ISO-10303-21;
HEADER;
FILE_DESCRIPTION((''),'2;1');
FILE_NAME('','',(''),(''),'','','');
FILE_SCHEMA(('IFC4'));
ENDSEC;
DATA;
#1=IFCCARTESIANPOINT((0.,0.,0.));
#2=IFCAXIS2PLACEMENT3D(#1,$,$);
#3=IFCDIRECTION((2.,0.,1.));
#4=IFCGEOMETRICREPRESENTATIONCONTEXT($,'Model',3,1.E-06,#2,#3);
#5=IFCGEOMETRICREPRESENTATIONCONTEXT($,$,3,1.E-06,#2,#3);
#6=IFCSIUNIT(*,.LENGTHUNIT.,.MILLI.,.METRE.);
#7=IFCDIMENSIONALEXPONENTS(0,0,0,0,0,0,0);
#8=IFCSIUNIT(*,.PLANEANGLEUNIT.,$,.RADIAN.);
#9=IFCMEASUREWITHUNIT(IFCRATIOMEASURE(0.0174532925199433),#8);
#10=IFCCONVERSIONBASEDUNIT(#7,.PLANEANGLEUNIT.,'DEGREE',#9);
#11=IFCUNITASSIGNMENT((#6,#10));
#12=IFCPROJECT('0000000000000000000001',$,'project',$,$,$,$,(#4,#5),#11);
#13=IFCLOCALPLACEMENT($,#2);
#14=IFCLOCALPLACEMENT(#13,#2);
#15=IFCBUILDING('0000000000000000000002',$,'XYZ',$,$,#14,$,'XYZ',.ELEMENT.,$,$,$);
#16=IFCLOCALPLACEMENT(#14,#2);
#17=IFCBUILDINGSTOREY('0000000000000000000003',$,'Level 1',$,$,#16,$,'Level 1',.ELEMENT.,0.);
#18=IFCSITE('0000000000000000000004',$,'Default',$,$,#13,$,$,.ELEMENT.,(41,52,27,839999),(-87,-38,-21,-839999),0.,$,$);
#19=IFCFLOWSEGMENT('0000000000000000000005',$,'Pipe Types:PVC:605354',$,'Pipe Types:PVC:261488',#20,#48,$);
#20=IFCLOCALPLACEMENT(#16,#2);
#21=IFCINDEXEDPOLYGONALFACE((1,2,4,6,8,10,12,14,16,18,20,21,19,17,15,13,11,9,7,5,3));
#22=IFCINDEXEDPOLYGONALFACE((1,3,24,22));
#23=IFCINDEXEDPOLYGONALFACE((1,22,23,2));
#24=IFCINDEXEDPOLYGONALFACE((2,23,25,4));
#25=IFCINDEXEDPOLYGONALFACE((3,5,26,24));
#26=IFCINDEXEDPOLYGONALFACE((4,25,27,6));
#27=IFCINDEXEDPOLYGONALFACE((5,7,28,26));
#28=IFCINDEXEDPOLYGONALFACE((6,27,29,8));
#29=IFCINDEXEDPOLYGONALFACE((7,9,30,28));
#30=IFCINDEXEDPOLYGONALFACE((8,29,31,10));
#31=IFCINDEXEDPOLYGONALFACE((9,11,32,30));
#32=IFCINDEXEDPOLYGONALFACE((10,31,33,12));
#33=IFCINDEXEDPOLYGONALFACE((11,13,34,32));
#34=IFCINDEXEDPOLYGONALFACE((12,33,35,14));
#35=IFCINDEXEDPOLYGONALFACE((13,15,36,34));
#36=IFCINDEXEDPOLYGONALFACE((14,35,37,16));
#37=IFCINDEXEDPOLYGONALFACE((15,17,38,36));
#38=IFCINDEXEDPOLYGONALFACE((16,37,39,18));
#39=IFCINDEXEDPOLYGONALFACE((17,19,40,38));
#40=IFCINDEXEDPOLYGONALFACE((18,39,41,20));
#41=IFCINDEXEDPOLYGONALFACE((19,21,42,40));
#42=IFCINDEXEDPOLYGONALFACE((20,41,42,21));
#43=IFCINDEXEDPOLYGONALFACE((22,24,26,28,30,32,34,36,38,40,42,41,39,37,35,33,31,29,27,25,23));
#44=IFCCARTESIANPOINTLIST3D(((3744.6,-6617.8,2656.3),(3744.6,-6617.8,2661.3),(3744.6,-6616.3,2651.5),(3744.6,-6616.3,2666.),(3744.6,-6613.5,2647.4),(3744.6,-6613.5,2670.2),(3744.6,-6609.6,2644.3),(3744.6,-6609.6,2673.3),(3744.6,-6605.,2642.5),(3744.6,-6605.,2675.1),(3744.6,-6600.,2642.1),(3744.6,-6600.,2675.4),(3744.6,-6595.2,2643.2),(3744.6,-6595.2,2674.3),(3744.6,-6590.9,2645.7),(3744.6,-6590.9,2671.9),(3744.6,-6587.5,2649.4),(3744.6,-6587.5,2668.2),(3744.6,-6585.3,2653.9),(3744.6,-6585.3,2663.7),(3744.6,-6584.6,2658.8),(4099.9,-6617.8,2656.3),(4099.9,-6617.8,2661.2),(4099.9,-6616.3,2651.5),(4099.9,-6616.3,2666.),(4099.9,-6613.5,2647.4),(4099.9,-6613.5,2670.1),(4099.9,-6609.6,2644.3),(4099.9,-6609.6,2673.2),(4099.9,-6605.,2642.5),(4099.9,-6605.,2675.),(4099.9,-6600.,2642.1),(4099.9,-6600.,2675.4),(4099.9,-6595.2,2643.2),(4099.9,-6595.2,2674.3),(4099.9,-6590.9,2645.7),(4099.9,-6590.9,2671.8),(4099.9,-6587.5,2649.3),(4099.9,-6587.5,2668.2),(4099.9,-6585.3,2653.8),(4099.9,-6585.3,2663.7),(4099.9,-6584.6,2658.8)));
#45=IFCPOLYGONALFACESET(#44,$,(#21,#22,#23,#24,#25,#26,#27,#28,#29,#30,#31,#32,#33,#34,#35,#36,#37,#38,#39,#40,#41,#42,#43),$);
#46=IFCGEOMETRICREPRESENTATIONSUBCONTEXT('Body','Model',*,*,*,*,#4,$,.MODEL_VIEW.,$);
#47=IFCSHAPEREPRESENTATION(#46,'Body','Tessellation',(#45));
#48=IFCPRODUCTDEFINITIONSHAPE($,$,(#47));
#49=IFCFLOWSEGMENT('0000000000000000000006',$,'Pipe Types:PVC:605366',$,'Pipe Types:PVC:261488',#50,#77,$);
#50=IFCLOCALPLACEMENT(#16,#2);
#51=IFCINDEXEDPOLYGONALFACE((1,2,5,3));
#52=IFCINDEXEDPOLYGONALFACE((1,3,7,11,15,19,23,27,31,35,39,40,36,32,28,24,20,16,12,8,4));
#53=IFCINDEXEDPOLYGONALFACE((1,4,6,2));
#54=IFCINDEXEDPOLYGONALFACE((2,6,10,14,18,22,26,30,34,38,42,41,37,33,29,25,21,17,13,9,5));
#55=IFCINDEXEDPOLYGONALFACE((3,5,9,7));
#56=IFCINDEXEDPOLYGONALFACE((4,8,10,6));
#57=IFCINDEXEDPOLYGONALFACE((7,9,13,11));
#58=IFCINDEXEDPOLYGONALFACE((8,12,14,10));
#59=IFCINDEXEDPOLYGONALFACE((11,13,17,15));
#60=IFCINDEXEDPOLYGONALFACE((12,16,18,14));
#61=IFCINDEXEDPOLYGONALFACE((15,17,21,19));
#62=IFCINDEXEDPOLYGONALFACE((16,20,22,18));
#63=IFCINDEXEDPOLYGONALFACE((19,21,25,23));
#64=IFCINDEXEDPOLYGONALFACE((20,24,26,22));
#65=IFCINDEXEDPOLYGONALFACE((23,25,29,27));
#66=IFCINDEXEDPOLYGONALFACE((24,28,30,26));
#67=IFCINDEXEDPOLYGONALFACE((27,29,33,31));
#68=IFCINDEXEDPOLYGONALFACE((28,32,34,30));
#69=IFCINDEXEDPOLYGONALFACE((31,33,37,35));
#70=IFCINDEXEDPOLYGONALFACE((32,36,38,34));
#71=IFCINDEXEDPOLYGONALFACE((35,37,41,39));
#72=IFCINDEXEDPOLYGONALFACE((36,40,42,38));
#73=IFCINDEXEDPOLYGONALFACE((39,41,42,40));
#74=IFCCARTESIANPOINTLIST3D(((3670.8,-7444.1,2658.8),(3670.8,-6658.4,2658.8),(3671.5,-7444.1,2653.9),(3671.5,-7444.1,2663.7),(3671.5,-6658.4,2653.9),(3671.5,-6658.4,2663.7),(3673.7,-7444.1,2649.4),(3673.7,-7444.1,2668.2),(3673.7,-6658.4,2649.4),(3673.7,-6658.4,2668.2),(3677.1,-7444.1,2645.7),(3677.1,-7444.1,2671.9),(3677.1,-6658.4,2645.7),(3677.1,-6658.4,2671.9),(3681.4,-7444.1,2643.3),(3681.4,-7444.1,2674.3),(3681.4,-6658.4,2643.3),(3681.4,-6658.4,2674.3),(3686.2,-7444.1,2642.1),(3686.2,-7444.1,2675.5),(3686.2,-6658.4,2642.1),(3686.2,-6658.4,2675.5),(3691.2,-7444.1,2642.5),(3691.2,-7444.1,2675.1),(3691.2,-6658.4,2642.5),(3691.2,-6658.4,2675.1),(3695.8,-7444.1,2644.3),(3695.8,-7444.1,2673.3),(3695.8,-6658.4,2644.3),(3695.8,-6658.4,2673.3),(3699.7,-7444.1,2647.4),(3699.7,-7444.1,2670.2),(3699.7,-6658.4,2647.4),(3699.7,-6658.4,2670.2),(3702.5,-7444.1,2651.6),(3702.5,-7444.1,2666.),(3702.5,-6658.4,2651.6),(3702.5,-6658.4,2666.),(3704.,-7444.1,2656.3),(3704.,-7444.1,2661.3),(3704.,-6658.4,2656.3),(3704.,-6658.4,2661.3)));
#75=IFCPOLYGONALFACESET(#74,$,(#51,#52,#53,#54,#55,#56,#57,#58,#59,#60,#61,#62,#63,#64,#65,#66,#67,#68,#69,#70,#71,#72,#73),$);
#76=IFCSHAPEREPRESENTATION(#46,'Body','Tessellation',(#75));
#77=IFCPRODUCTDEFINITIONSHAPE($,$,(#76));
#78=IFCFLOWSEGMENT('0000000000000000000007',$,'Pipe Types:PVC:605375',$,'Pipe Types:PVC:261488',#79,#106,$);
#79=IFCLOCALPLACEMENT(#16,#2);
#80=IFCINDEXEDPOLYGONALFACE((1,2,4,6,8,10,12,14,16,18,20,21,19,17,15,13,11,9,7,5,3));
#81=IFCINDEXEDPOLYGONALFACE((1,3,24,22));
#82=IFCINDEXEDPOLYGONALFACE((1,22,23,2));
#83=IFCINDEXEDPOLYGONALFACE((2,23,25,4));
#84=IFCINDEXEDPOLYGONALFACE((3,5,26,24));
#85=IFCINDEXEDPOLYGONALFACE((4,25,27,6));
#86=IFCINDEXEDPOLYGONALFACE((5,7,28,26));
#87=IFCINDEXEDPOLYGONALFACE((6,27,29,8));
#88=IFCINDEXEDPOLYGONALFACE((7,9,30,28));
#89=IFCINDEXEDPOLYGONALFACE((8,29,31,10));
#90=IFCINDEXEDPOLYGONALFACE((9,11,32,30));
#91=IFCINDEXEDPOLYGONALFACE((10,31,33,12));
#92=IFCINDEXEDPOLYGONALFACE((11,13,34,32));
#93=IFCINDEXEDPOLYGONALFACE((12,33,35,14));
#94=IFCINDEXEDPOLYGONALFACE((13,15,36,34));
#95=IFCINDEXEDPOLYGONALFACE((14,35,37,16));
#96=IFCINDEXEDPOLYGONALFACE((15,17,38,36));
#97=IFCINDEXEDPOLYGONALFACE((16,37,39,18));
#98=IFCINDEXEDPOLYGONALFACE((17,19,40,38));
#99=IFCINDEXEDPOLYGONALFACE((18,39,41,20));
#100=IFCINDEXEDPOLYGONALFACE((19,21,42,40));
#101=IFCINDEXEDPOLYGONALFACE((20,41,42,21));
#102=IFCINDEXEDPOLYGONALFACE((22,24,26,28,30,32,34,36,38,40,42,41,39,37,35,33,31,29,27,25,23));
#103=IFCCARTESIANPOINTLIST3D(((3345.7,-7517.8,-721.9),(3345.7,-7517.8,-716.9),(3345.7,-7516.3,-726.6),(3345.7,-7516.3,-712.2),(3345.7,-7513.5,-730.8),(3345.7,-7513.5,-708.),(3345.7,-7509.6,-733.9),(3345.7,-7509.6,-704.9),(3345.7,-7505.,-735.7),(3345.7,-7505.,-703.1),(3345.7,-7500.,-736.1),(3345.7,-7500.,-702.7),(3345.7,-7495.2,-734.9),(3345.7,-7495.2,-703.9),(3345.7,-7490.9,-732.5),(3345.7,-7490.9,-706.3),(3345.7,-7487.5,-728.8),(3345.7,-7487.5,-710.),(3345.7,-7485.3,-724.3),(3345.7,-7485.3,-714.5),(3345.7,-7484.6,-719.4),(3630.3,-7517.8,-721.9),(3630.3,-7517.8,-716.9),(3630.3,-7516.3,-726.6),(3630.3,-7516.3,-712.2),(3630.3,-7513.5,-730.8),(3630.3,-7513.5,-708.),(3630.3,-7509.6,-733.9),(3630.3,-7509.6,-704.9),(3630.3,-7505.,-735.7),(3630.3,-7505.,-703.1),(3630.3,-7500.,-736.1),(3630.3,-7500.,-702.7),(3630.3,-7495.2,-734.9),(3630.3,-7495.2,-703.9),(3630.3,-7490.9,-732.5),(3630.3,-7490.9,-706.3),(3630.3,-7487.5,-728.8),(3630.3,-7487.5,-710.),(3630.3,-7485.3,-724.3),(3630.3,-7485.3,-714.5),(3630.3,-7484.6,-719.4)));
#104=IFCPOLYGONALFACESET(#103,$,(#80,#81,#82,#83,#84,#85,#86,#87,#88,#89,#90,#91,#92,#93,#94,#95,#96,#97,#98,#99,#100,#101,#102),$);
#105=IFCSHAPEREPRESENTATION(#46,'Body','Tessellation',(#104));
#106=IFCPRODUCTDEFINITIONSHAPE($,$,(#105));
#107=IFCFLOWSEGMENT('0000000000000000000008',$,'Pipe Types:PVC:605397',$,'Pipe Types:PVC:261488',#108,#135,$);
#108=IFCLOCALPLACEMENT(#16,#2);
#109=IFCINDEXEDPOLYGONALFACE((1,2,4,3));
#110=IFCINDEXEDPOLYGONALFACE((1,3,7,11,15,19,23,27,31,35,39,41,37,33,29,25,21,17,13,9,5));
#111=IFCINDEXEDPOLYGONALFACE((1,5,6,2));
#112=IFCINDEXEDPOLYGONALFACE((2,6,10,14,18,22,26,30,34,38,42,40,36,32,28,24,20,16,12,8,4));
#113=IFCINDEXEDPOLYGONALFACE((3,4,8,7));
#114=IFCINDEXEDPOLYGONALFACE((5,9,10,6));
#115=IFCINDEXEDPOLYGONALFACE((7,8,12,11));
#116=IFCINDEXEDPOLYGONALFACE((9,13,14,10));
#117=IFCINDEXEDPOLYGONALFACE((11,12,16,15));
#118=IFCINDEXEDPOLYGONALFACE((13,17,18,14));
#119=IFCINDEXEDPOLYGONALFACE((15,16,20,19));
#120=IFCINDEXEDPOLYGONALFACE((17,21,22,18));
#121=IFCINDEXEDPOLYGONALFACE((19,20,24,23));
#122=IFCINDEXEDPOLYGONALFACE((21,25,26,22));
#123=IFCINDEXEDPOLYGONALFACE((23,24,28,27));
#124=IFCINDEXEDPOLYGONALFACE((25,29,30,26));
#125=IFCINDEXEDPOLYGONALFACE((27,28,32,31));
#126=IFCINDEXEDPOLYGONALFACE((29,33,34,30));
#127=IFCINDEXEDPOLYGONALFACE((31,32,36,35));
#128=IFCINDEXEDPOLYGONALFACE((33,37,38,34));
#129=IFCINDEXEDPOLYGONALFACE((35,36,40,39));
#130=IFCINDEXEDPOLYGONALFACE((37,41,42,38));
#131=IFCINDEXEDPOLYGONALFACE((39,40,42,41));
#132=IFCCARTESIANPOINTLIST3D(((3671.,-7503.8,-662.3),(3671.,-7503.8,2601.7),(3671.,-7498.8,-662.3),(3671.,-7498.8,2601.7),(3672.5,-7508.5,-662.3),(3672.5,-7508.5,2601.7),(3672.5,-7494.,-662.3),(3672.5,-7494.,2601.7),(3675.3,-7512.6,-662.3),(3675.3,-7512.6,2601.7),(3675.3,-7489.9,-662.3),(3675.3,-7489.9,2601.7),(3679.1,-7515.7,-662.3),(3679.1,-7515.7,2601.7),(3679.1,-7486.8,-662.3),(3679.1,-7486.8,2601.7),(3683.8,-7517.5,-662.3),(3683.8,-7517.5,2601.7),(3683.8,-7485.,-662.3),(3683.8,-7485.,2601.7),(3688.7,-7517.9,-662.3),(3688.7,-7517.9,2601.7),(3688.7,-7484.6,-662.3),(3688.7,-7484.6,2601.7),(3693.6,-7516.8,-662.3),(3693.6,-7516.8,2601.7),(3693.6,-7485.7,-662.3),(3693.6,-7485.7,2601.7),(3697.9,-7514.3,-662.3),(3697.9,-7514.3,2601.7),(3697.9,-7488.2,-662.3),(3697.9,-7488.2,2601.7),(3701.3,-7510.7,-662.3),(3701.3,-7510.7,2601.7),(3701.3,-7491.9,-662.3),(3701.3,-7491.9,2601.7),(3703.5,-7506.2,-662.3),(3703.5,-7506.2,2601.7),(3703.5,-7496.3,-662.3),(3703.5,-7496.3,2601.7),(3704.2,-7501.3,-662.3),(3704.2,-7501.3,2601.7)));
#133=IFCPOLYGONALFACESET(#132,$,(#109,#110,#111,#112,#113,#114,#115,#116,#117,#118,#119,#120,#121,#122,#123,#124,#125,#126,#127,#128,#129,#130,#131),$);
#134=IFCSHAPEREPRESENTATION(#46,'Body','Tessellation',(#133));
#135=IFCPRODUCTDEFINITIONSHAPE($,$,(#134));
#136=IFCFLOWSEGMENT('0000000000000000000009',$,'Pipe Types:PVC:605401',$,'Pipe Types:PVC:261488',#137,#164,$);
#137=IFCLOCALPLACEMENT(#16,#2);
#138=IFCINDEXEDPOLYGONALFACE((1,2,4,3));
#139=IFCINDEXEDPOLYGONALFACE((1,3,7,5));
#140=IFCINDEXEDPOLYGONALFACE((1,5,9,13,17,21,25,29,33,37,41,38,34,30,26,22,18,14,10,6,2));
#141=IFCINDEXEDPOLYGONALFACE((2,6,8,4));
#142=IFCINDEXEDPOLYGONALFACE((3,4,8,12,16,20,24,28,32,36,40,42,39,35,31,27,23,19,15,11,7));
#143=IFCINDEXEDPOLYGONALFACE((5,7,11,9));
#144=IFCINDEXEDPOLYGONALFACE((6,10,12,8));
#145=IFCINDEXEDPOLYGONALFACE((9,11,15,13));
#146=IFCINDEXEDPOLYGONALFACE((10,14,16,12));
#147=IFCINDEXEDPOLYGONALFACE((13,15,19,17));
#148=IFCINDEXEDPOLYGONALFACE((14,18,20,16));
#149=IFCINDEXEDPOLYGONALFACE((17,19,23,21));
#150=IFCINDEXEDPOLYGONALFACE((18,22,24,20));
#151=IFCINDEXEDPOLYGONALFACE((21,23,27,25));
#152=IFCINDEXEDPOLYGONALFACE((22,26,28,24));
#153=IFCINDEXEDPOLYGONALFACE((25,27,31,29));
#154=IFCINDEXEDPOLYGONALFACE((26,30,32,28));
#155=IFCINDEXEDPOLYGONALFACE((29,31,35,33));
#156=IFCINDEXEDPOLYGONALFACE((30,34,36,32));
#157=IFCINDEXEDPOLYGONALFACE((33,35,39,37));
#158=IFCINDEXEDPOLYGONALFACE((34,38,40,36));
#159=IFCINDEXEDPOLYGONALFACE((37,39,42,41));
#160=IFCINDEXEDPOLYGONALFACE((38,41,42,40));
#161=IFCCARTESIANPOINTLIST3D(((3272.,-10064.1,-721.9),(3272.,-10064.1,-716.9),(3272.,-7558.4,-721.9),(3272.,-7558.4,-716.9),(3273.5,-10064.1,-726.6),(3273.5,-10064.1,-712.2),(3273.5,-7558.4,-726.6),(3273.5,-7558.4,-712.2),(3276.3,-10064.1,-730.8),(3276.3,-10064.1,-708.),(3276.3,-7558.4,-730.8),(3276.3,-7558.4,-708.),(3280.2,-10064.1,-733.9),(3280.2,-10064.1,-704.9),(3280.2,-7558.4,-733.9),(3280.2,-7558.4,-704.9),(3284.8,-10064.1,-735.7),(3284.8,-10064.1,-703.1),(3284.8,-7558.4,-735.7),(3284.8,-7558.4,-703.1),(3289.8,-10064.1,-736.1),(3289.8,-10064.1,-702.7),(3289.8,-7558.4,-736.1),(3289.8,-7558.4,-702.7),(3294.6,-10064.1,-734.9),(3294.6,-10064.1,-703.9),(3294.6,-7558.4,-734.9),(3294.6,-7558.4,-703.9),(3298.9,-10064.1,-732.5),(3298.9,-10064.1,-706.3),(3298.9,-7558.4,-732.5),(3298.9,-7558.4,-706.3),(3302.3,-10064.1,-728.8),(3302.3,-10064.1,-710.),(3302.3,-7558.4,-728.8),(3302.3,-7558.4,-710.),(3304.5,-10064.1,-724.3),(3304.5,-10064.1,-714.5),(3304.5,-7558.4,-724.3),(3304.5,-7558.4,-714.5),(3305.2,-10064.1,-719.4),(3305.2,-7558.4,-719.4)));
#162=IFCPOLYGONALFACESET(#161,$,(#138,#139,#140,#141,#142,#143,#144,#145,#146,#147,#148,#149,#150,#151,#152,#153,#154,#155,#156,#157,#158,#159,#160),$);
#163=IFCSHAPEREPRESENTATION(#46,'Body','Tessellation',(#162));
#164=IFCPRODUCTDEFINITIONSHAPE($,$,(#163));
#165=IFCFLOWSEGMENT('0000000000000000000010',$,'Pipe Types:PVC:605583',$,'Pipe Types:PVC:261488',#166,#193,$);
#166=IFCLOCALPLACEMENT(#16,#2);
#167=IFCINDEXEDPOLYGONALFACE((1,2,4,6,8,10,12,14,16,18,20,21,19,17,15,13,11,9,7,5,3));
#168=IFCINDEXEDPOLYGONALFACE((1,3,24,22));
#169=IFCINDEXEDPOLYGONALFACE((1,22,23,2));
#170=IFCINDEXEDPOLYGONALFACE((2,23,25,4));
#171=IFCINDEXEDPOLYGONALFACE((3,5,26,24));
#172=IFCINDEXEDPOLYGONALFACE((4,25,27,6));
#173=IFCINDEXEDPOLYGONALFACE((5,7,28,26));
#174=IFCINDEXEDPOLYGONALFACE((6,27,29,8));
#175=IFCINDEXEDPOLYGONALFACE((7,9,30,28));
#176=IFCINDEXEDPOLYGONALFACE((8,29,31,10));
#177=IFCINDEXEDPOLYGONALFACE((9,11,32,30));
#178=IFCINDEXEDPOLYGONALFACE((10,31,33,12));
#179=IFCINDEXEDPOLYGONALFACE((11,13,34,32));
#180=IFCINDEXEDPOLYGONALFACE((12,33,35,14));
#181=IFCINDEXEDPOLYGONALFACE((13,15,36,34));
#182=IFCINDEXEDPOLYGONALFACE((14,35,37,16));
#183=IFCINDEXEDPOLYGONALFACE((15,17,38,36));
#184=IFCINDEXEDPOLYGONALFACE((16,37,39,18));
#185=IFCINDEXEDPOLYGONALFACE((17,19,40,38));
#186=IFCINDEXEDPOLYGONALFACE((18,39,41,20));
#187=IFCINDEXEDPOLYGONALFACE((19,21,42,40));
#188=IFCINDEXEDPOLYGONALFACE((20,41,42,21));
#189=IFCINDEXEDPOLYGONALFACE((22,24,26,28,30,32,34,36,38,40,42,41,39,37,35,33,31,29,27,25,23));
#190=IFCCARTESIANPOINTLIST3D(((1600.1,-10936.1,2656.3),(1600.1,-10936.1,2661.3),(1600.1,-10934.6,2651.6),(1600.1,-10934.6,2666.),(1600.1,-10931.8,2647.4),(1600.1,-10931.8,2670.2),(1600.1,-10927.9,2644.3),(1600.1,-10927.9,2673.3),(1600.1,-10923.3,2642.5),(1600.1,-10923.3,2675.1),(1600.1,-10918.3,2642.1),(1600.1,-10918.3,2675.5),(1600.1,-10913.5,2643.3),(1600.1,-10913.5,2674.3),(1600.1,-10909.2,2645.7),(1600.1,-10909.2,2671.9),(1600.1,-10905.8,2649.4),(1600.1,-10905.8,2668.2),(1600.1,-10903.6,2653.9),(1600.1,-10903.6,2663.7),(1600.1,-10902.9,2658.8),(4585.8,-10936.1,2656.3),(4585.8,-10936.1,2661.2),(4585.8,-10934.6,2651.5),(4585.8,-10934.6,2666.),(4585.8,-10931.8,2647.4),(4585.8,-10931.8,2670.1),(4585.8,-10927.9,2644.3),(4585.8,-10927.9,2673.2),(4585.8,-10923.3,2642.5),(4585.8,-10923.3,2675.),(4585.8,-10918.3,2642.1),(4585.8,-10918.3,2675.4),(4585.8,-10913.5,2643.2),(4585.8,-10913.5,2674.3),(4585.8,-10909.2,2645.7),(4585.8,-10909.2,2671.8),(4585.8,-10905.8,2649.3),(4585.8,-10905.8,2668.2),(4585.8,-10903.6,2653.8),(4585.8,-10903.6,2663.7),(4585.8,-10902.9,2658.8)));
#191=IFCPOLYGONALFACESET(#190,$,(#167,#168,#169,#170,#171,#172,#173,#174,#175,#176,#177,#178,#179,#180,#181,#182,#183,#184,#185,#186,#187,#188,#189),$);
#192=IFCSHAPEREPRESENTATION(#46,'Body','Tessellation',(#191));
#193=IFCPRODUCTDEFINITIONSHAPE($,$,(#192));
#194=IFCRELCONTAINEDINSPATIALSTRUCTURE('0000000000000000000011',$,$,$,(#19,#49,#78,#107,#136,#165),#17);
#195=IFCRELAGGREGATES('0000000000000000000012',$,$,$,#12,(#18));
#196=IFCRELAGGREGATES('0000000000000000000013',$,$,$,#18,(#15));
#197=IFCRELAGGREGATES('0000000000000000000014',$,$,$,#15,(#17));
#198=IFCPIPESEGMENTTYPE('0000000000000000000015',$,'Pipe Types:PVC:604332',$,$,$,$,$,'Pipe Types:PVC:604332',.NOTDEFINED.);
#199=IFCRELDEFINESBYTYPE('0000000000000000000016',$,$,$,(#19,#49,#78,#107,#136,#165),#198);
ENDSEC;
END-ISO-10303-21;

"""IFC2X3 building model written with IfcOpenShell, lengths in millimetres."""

from ifc_helpers import new_model, entity, si_unit, converted_unit, direction, frame, frame_2d, origin, origin_2d_with_axis, place, context, subcontext, project, spatial, circle, extrude, type_object, element, save


model = new_model("IFC2X3")

# Units and contexts
model_context = context("Model", 3, precision=1e-06, world=origin(), true_north=direction((2.0, 0.0, 1.0)))
context_of_model = context(None, 3, precision=1e-06, world=origin(), true_north=direction((2.0, 0.0, 1.0)))
body_context = subcontext(model_context, "Body", "Model", "MODEL_VIEW")
ifc_project = project(units=[si_unit("LENGTHUNIT", "METRE", prefix="MILLI"), converted_unit("PLANEANGLEUNIT", "DEGREE", entity("IfcRatioMeasure", 0.0174532925199433), si_unit("PLANEANGLEUNIT", "RADIAN"), dimensions=[0, 0, 0, 0, 0, 0, 0])], contexts=[model_context, context_of_model])

# Site, building, storey
site_placement = place(None, origin())
site = spatial("IfcSite", under=ifc_project, at=site_placement, Name="Default", CompositionType="ELEMENT", RefLatitude=(41, 52, 27, 839999), RefLongitude=(-87, -38, -21, -839999), RefElevation=0.0)
building_placement = place(site_placement, origin())
building = spatial("IfcBuilding", under=site, at=building_placement, Name="XYZ", LongName="XYZ", CompositionType="ELEMENT")
storey_placement = place(building_placement, origin())
storey = spatial("IfcBuildingStorey", under=building, at=storey_placement, Name="Level 1", LongName="Level 1", CompositionType="ELEMENT", Elevation=0.0)

# Flow segments
pipe_segment_type_1 = type_object("IfcPipeSegmentType", Name="Pipe Types:PVC:604332", ElementType="Pipe Types:PVC:604332", PredefinedType="NOTDEFINED")
flow_segment_1_placement = place(storey_placement, origin())
element("IfcFlowSegment", 1, at=flow_segment_1_placement, inside=storey, type_object=pipe_segment_type_1, Name="Pipe Types:PVC:605354", ObjectType="Pipe Types:PVC:261488", context=body_context, shape_type="SweptSolid", body=[
    extrude(circle(Radius=16.7, at=origin_2d_with_axis()), frame((4099.9, -6601.3, 2658.8), z_axis=(-1.0, 0.0, 0.000119), x_axis=(0.0, 1.0, 0.0)), (0.0, 0.0, 1.0), 355.2),
])
flow_segment_2_placement = place(storey_placement, origin())
element("IfcFlowSegment", 2, at=flow_segment_2_placement, inside=storey, type_object=pipe_segment_type_1, Name="Pipe Types:PVC:605366", ObjectType="Pipe Types:PVC:261488", context=body_context, shape_type="SweptSolid", body=[
    extrude(circle(Radius=16.7, at=frame_2d((0.0, 0.0), x_axis=(1.0, 0.0))), frame((3687.5, -7444.1, 2658.8), z_axis=(0.0, 1.0, 0.0), x_axis=(-1.0, 0.0, 0.0)), (0.0, 0.0, 1.0), 785.7),
])
flow_segment_3_placement = place(storey_placement, origin())
element("IfcFlowSegment", 3, at=flow_segment_3_placement, inside=storey, type_object=pipe_segment_type_1, Name="Pipe Types:PVC:605375", ObjectType="Pipe Types:PVC:261488", context=body_context, shape_type="SweptSolid", body=[
    extrude(circle(Radius=16.7, at=frame_2d((0.0, 0.0), x_axis=(1.0, 0.0))), frame((3345.7, -7501.3, -719.4), z_axis=(1.0, 0.0, 0.0), x_axis=(0.0, 1.0, 0.0)), (0.0, 0.0, 1.0), 284.7),
])
flow_segment_4_placement = place(storey_placement, origin())
element("IfcFlowSegment", 4, at=flow_segment_4_placement, inside=storey, type_object=pipe_segment_type_1, Name="Pipe Types:PVC:605397", ObjectType="Pipe Types:PVC:261488", context=body_context, shape_type="SweptSolid", body=[
    extrude(circle(Radius=16.7, at=origin_2d_with_axis()), frame((3687.5, -7501.3, -662.3)), (0.0, 0.0, 1.0), 3263.9),
])
flow_segment_5_placement = place(storey_placement, origin())
element("IfcFlowSegment", 5, at=flow_segment_5_placement, inside=storey, type_object=pipe_segment_type_1, Name="Pipe Types:PVC:605401", ObjectType="Pipe Types:PVC:261488", context=body_context, shape_type="SweptSolid", body=[
    extrude(circle(Radius=16.7, at=origin_2d_with_axis()), frame((3288.5, -10064.1, -719.4), z_axis=(0.0, 1.0, 0.0), x_axis=(1.0, 0.0, 0.0)), (0.0, 0.0, 1.0), 2505.7),
])
flow_segment_6_placement = place(storey_placement, origin())
element("IfcFlowSegment", 6, at=flow_segment_6_placement, inside=storey, type_object=pipe_segment_type_1, Name="Pipe Types:PVC:605583", ObjectType="Pipe Types:PVC:261488", context=body_context, shape_type="SweptSolid", body=[
    extrude(circle(Radius=16.7, at=origin_2d_with_axis()), frame((4585.8, -10919.6, 2658.8), z_axis=(-1.0, 0.0, 0.000016), x_axis=(0.0, 1.0, 0.0)), (0.0, 0.0, 1.0), 2985.7),
])

save(model, "model.ifc")
